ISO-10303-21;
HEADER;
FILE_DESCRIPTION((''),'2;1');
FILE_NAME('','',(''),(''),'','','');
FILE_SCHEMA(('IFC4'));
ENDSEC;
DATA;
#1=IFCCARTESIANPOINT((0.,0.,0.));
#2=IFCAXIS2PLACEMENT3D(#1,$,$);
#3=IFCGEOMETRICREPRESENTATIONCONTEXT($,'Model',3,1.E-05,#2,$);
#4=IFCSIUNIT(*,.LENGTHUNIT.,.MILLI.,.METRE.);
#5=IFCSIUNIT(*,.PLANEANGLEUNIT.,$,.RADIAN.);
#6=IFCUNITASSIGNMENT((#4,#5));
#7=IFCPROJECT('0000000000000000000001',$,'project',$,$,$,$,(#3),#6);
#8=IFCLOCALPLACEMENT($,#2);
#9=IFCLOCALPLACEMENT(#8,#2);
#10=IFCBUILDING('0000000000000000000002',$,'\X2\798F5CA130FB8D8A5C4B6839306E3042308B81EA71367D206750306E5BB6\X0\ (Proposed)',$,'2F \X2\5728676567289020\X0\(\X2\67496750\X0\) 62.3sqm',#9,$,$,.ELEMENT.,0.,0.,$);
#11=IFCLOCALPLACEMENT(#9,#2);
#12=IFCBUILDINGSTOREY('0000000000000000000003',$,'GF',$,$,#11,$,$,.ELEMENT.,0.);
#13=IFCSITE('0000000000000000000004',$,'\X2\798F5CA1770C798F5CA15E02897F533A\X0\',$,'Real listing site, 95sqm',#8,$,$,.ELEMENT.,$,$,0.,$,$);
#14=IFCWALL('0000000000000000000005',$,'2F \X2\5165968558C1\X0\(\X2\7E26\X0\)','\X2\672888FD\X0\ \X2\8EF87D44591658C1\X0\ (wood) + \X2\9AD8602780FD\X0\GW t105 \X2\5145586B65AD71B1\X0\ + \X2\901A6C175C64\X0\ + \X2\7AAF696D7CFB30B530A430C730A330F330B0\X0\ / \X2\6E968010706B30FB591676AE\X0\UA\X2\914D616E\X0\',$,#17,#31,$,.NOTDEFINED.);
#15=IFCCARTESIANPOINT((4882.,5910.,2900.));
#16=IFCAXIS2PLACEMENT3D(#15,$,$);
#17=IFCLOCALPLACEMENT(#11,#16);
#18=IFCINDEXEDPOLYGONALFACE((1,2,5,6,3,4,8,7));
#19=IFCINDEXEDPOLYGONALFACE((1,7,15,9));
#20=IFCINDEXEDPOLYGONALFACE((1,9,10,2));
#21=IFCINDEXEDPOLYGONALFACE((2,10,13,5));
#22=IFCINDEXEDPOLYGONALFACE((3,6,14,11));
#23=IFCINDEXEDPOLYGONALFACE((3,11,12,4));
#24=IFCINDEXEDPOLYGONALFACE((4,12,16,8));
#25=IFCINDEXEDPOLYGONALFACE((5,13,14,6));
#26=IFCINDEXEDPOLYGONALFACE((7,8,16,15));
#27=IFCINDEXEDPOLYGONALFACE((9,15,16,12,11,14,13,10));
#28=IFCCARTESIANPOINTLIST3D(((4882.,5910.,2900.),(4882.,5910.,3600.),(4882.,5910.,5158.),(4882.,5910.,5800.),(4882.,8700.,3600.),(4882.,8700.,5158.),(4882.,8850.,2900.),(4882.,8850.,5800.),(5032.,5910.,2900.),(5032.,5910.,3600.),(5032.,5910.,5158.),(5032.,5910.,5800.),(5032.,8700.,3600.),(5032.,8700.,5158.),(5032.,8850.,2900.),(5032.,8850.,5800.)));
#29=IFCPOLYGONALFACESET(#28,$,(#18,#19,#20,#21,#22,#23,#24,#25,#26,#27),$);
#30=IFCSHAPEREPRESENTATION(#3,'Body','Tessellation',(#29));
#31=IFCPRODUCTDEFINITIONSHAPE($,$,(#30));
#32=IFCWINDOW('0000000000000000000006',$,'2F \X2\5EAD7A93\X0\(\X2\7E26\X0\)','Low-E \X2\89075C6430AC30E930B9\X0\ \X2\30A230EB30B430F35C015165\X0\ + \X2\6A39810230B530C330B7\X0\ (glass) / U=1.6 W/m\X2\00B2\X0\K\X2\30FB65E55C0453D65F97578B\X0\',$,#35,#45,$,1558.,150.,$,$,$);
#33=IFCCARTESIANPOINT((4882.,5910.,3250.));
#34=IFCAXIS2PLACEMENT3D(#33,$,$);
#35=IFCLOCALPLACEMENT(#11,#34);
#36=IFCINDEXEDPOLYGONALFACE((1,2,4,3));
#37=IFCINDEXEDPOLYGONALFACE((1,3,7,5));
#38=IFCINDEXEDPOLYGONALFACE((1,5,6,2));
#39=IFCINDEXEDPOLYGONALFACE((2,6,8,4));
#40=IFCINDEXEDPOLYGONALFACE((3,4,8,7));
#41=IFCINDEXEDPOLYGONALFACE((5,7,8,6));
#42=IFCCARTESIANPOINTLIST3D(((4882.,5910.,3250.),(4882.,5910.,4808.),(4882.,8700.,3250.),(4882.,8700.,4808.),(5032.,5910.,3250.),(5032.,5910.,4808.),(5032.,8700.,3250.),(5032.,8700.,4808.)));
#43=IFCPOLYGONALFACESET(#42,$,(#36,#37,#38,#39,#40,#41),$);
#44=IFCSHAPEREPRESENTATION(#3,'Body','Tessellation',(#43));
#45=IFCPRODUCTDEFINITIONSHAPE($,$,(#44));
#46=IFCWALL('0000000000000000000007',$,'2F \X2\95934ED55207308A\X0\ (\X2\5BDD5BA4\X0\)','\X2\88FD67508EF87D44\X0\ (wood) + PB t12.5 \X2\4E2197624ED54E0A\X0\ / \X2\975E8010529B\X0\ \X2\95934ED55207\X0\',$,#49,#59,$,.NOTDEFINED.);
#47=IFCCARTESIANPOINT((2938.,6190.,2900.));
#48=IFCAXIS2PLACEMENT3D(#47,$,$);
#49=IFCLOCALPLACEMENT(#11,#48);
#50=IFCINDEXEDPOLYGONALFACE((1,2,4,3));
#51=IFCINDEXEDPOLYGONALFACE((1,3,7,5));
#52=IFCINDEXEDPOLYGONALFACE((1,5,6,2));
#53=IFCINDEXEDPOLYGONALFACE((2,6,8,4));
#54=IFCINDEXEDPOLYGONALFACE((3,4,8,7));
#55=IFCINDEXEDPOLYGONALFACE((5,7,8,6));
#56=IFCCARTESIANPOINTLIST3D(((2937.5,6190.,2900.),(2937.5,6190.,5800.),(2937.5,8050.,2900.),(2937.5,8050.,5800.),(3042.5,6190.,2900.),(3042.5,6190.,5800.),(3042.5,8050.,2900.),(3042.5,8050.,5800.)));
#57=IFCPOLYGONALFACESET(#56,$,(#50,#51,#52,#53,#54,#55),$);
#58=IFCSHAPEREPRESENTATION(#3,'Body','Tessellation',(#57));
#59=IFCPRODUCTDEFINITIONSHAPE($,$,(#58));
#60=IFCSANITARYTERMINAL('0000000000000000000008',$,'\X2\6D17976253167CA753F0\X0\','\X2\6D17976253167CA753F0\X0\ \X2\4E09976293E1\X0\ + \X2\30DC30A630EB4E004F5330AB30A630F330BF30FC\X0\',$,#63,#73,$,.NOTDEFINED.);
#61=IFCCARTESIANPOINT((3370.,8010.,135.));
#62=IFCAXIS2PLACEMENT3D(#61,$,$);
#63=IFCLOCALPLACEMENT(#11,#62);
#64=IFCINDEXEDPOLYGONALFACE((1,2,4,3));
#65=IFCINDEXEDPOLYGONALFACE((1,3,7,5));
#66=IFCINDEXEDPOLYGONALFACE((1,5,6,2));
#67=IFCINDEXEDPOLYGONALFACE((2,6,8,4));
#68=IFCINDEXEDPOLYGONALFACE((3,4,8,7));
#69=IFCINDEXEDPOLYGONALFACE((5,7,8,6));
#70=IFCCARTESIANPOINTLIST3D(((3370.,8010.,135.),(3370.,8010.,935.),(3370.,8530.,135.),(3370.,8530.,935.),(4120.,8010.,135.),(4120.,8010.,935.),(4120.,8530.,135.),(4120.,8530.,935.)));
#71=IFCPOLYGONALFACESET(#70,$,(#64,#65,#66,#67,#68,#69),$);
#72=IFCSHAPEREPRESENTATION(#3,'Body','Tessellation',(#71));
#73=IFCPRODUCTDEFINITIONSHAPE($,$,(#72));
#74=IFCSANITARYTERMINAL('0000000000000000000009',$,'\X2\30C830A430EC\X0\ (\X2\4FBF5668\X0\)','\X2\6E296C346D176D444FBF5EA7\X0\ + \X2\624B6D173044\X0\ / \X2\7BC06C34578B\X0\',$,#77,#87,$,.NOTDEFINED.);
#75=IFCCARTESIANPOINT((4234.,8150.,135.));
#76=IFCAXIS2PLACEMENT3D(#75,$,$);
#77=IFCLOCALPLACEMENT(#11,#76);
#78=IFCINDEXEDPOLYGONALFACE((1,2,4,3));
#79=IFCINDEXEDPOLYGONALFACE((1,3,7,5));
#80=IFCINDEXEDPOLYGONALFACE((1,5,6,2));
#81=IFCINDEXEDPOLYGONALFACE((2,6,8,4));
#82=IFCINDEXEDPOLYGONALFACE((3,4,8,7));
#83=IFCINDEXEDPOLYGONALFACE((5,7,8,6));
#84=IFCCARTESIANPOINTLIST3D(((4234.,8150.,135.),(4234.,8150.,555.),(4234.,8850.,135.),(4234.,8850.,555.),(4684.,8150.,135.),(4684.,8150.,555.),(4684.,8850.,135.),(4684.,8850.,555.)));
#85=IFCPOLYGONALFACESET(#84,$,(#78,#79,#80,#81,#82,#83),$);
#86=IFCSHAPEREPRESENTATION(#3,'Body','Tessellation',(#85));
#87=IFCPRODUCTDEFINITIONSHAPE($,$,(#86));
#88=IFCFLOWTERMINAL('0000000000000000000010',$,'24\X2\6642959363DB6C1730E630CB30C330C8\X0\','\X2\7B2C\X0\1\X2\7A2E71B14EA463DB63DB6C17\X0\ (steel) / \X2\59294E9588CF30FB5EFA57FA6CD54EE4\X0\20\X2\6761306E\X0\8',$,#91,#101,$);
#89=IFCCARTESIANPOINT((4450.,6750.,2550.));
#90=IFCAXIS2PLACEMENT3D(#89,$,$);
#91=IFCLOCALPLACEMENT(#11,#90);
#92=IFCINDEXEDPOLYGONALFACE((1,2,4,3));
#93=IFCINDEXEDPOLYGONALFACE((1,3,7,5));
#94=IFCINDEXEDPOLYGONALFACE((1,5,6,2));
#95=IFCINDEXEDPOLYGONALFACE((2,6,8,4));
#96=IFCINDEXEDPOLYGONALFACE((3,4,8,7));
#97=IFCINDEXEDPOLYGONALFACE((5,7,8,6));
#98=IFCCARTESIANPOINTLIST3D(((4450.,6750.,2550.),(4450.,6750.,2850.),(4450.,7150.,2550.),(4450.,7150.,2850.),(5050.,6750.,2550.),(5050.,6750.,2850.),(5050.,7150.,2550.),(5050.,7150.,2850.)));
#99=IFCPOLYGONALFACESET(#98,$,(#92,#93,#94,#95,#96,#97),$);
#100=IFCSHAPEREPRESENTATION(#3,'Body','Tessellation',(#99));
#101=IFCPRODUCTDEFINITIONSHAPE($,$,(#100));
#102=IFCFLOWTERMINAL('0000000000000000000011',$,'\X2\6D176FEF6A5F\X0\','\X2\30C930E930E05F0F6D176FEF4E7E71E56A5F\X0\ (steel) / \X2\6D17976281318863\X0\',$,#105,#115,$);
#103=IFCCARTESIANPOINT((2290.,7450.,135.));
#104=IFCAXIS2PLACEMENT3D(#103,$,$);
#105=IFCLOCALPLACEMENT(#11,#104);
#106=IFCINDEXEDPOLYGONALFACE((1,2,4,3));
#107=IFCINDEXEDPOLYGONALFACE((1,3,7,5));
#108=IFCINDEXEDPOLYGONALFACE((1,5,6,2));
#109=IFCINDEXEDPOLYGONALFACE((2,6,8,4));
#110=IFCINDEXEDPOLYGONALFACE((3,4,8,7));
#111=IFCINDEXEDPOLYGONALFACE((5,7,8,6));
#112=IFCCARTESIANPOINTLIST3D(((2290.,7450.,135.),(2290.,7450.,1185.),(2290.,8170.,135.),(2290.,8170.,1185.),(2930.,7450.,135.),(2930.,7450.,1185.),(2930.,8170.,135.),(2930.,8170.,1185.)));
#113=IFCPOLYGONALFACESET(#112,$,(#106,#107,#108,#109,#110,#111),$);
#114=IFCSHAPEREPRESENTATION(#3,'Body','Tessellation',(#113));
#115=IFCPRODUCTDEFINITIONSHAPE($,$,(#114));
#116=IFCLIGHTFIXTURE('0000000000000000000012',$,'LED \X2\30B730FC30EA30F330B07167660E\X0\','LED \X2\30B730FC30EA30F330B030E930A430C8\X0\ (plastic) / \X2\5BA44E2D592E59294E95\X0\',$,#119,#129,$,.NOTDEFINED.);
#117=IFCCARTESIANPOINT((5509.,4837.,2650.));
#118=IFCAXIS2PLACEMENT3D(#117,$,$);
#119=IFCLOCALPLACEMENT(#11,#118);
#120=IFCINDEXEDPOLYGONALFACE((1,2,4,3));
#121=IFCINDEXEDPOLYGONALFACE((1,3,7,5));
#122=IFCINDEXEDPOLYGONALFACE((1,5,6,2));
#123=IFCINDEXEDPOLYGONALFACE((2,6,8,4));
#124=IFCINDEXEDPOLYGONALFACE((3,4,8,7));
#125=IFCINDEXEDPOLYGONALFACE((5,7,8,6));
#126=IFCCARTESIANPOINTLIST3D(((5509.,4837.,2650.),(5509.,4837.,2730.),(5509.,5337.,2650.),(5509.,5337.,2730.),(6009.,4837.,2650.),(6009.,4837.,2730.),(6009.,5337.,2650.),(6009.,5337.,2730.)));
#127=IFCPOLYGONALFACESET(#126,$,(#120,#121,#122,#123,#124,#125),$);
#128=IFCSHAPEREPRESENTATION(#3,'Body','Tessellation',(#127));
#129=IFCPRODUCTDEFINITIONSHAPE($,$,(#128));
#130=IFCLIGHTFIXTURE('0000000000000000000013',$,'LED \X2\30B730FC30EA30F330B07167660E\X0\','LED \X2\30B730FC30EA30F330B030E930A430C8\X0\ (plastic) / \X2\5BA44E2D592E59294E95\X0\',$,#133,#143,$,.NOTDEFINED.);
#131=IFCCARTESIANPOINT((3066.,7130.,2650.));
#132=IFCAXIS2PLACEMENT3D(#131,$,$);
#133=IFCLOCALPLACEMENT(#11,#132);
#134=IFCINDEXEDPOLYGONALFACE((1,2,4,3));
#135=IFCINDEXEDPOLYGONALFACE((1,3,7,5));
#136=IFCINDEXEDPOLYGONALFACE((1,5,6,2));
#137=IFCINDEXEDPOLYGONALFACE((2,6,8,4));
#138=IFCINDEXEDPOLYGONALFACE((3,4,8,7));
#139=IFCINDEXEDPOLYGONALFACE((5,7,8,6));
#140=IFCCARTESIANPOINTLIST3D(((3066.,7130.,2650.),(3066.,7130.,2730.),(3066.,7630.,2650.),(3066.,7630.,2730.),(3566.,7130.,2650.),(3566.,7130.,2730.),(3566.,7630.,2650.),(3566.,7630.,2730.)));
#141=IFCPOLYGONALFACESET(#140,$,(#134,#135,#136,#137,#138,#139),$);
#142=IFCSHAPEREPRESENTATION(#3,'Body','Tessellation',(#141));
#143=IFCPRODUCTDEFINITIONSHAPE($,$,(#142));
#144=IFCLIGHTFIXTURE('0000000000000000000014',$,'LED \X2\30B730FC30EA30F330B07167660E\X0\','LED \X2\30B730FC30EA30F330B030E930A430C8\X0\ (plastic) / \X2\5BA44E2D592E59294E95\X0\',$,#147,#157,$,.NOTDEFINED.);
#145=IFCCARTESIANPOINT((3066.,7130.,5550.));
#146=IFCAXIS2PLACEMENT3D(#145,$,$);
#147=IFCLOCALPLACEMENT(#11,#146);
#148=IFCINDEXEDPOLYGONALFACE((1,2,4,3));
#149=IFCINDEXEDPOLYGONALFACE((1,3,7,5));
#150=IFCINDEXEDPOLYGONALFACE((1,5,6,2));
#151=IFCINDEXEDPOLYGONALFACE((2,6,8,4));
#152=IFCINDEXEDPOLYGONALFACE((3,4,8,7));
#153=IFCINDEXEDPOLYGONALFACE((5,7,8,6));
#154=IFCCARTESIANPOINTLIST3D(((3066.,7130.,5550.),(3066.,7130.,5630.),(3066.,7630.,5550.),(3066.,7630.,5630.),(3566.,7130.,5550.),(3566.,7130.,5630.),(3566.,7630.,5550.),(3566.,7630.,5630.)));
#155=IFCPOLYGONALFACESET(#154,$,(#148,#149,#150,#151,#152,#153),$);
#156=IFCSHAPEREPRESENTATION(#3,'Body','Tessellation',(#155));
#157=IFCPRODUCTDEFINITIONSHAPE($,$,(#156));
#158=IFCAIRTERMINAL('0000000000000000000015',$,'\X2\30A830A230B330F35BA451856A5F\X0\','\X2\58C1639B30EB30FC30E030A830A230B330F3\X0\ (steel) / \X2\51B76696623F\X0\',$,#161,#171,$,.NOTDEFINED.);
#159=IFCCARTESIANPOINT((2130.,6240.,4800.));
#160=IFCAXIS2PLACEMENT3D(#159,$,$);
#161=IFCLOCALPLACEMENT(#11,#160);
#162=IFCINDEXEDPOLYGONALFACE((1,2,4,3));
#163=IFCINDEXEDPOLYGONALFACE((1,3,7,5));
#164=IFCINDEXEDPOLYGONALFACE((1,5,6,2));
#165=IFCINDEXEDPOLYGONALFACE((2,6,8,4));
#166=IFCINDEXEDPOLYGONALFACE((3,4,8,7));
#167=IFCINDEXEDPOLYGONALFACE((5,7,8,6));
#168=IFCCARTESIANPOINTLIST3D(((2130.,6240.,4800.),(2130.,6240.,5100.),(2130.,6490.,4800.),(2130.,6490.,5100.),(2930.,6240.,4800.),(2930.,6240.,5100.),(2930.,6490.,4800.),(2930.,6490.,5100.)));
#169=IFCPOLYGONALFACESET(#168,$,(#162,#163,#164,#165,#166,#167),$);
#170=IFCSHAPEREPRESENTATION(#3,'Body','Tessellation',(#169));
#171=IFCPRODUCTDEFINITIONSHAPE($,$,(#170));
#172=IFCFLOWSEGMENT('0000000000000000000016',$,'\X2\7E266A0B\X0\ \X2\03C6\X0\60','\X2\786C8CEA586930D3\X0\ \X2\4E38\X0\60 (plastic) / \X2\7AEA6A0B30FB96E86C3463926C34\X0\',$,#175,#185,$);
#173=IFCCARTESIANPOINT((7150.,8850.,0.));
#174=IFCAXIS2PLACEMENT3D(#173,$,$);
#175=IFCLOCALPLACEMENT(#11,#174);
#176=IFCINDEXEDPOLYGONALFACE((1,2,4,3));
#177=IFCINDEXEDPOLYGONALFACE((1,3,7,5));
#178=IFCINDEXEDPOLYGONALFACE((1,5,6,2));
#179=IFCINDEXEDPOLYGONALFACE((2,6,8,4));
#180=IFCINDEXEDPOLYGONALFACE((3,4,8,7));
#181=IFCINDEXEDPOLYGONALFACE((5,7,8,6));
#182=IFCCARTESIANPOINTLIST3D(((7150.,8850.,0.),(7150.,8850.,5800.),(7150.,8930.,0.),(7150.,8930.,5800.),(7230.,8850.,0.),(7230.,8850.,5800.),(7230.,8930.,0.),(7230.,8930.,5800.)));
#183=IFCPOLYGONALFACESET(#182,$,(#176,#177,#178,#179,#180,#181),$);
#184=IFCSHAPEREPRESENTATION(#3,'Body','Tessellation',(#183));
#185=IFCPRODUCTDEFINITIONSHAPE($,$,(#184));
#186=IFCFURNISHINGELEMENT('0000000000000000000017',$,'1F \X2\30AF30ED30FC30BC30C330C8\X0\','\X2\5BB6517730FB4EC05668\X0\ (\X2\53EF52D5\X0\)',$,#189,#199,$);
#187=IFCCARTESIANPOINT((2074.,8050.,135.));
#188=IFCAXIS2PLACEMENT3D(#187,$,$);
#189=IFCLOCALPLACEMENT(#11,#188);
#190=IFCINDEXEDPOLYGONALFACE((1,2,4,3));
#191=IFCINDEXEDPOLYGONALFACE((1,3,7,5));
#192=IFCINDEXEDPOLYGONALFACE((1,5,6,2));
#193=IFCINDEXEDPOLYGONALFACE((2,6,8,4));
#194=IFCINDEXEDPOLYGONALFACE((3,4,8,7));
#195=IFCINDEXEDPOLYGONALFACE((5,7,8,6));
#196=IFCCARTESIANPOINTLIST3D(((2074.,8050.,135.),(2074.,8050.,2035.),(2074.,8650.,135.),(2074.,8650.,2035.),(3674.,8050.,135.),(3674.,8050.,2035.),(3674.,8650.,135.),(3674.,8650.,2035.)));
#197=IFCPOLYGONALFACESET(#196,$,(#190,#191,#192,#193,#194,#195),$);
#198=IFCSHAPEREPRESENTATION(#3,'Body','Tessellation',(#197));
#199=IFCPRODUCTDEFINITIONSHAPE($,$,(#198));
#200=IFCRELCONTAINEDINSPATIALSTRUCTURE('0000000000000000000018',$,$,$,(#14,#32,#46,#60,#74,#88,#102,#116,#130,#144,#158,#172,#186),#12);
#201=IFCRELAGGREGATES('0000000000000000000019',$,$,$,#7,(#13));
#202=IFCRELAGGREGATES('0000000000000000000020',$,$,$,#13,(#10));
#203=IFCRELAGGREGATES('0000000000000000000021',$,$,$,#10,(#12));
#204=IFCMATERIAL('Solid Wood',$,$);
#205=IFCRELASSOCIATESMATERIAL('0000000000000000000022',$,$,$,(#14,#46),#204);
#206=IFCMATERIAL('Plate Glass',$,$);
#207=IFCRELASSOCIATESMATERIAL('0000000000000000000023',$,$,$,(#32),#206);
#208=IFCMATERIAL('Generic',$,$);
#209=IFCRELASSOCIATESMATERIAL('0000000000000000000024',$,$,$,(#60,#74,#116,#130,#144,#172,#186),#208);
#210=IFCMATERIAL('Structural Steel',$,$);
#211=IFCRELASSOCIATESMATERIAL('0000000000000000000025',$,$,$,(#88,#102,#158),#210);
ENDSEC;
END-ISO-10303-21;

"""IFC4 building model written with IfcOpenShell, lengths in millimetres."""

from ifc_helpers import new_model, si_unit, frame, frame_2d, origin, place, context, project, spatial, rectangle, extrude, material, element, fill, save


model = new_model("IFC4")

# Units and contexts
model_context = context("Model", 3, precision=1e-05, world=origin())
ifc_project = project(units=[si_unit("LENGTHUNIT", "METRE", prefix="MILLI"), si_unit("PLANEANGLEUNIT", "RADIAN")], contexts=[model_context])

# Site, building, storey
site_placement = place(None, origin())
site = spatial("IfcSite", under=ifc_project, at=site_placement, Name="福岡県福岡市西区", ObjectType="Real listing site, 95sqm", CompositionType="ELEMENT", RefElevation=0.0)
building_placement = place(site_placement, origin())
building = spatial("IfcBuilding", under=site, at=building_placement, Name="福岡・越屋根のある自然素材の家 (Proposed)", ObjectType="2F 在来木造(杉材) 62.3sqm", CompositionType="ELEMENT", ElevationOfRefHeight=0.0, ElevationOfTerrain=0.0)
storey_placement = place(building_placement, origin())
storey = spatial("IfcBuildingStorey", under=building, at=storey_placement, Name="GF", CompositionType="ELEMENT", Elevation=0.0)

# Shared definitions
ifc_material_1 = material(Name="Solid Wood")

# Shared definitions
ifc_material_2 = material(Name="Plate Glass")

# Wall, opening, window
wall_1_placement = place(storey_placement, frame((4882.0, 5910.0, 2900.0)))
wall_1 = element("IfcWall", 1, at=wall_1_placement, inside=storey, material=ifc_material_1, Name="2F 入隅壁(縦)", Description="木製 軸組外壁 (wood) + 高性能GW t105 充填断熱 + 通気層 + 窯業系サイディング / 準耐火・外皮UA配慮", PredefinedType="NOTDEFINED", context=model_context, shape_type="SweptSolid", body=[
    extrude(rectangle(XDim=150.0, YDim=2940.0, at=frame_2d((75.0, 1470.0))), frame((4882.0, 5910.0, 2900.0)), (0.0, 0.0, 1.0), 2900.0),
])
opening_1_placement = place(storey_placement, frame((4882.0, 5910.0, 3250.0)))
opening_1 = element("IfcOpeningElement", 2, at=opening_1_placement, cuts=wall_1, PredefinedType="NOTDEFINED", context=model_context, shape_type="SweptSolid", body=[
    extrude(rectangle(XDim=150.0, YDim=2790.0, at=frame_2d((75.0, 1395.0))), frame((4882.0, 5910.0, 3250.0)), (0.0, 0.0, 1.0), 1558.0),
])
window_1_placement = place(storey_placement, frame((4882.0, 5910.0, 3250.0)))
window_1 = element("IfcWindow", 3, at=window_1_placement, inside=storey, material=ifc_material_2, Name="2F 庭窓(縦)", Description="Low-E 複層ガラス アルゴン封入 + 樹脂サッシ (glass) / U=1.6 W/m²K・日射取得型", OverallHeight=1558.0, OverallWidth=150.0, context=model_context, shape_type="SweptSolid", body=[
    extrude(rectangle(XDim=150.0, YDim=2790.0, at=frame_2d((75.0, 1395.0))), frame((4882.0, 5910.0, 3250.0)), (0.0, 0.0, 1.0), 1558.0),
])
fill(opening_1, window_1)

# Wall
wall_2_placement = place(storey_placement, frame((2938.0, 6190.0, 2900.0)))
element("IfcWall", 4, at=wall_2_placement, inside=storey, material=ifc_material_1, Name="2F 間仕切り (寝室)", Description="製材軸組 (wood) + PB t12.5 両面仕上 / 非耐力 間仕切", PredefinedType="NOTDEFINED", context=model_context, shape_type="SweptSolid", body=[
    extrude(rectangle(XDim=105.0, YDim=1860.0, at=frame_2d((52.0, 930.0))), frame((2938.0, 6190.0, 2900.0)), (0.0, 0.0, 1.0), 2900.0),
])

# Sanitary terminals
ifc_material_3 = material(Name="Generic")
sanitary_terminal_1_placement = place(storey_placement, frame((3370.0, 8010.0, 135.0)))
element("IfcSanitaryTerminal", 5, at=sanitary_terminal_1_placement, inside=storey, material=ifc_material_3, Name="洗面化粧台", Description="洗面化粧台 三面鏡 + ボウル一体カウンター", PredefinedType="NOTDEFINED", context=model_context, shape_type="SweptSolid", body=[
    extrude(rectangle(XDim=750.0, YDim=520.0, at=frame_2d((375.0, 260.0))), frame((3370.0, 8010.0, 135.0)), (0.0, 0.0, 1.0), 800.0),
])
sanitary_terminal_2_placement = place(storey_placement, frame((4234.0, 8150.0, 135.0)))
element("IfcSanitaryTerminal", 6, at=sanitary_terminal_2_placement, inside=storey, material=ifc_material_3, Name="トイレ (便器)", Description="温水洗浄便座 + 手洗い / 節水型", PredefinedType="NOTDEFINED", context=model_context, shape_type="SweptSolid", body=[
    extrude(rectangle(XDim=450.0, YDim=700.0, at=frame_2d((225.0, 350.0))), frame((4234.0, 8150.0, 135.0)), (0.0, 0.0, 1.0), 420.0),
])

# Flow terminals
ifc_material_4 = material(Name="Structural Steel")
flow_terminal_1_placement = place(storey_placement, frame((4450.0, 6750.0, 2550.0)))
element("IfcFlowTerminal", 7, at=flow_terminal_1_placement, inside=storey, material=ifc_material_4, Name="24時間換気ユニット", Description="第1種熱交換換気 (steel) / 天井裏・建基法令20条の8", context=model_context, shape_type="SweptSolid", body=[
    extrude(rectangle(XDim=600.0, YDim=400.0, at=frame_2d((300.0, 200.0))), frame((4450.0, 6750.0, 2550.0)), (0.0, 0.0, 1.0), 300.0),
])
flow_terminal_2_placement = place(storey_placement, frame((2290.0, 7450.0, 135.0)))
element("IfcFlowTerminal", 8, at=flow_terminal_2_placement, inside=storey, material=ifc_material_4, Name="洗濯機", Description="ドラム式洗濯乾燥機 (steel) / 洗面脱衣", context=model_context, shape_type="SweptSolid", body=[
    extrude(rectangle(XDim=640.0, YDim=720.0, at=frame_2d((320.0, 360.0))), frame((2290.0, 7450.0, 135.0)), (0.0, 0.0, 1.0), 1050.0),
])

# Light fixtures
light_fixture_1_placement = place(storey_placement, frame((5509.0, 4837.0, 2650.0)))
element("IfcLightFixture", 9, at=light_fixture_1_placement, inside=storey, material=ifc_material_3, Name="LED シーリング照明", Description="LED シーリングライト (plastic) / 室中央天井", PredefinedType="NOTDEFINED", context=model_context, shape_type="SweptSolid", body=[
    extrude(rectangle(XDim=500.0, YDim=500.0, at=frame_2d((250.0, 250.0))), frame((5509.0, 4837.0, 2650.0)), (0.0, 0.0, 1.0), 80.0),
])
light_fixture_2_placement = place(storey_placement, frame((3066.0, 7130.0, 2650.0)))
element("IfcLightFixture", 10, at=light_fixture_2_placement, inside=storey, material=ifc_material_3, Name="LED シーリング照明", Description="LED シーリングライト (plastic) / 室中央天井", PredefinedType="NOTDEFINED", context=model_context, shape_type="SweptSolid", body=[
    extrude(rectangle(XDim=500.0, YDim=500.0, at=frame_2d((250.0, 250.0))), frame((3066.0, 7130.0, 2650.0)), (0.0, 0.0, 1.0), 80.0),
])
light_fixture_3_placement = place(storey_placement, frame((3066.0, 7130.0, 5550.0)))
element("IfcLightFixture", 11, at=light_fixture_3_placement, inside=storey, material=ifc_material_3, Name="LED シーリング照明", Description="LED シーリングライト (plastic) / 室中央天井", PredefinedType="NOTDEFINED", context=model_context, shape_type="SweptSolid", body=[
    extrude(rectangle(XDim=500.0, YDim=500.0, at=frame_2d((250.0, 250.0))), frame((3066.0, 7130.0, 5550.0)), (0.0, 0.0, 1.0), 80.0),
])

# Air terminal
air_terminal_placement = place(storey_placement, frame((2130.0, 6240.0, 4800.0)))
element("IfcAirTerminal", 12, at=air_terminal_placement, inside=storey, material=ifc_material_4, Name="エアコン室内機", Description="壁掛ルームエアコン (steel) / 冷暖房", PredefinedType="NOTDEFINED", context=model_context, shape_type="SweptSolid", body=[
    extrude(rectangle(XDim=800.0, YDim=250.0, at=frame_2d((400.0, 125.0))), frame((2130.0, 6240.0, 4800.0)), (0.0, 0.0, 1.0), 300.0),
])

# Flow segment
flow_segment_placement = place(storey_placement, frame((7150.0, 8850.0, 0.0)))
element("IfcFlowSegment", 13, at=flow_segment_placement, inside=storey, material=ifc_material_3, Name="縦樋 φ60", Description="硬質塩ビ 丸60 (plastic) / 竪樋・雨水排水", context=model_context, shape_type="SweptSolid", body=[
    extrude(rectangle(XDim=80.0, YDim=80.0, at=frame_2d((40.0, 40.0))), frame((7150.0, 8850.0, 0.0)), (0.0, 0.0, 1.0), 5800.0),
])

# Furnishing element
furnishing_1_placement = place(storey_placement, frame((2074.0, 8050.0, 135.0)))
element("IfcFurnishingElement", 14, at=furnishing_1_placement, inside=storey, material=ifc_material_3, Name="1F クローゼット", Description="家具・什器 (可動)", context=model_context, shape_type="SweptSolid", body=[
    extrude(rectangle(XDim=1600.0, YDim=600.0, at=frame_2d((800.0, 300.0))), frame((2074.0, 8050.0, 135.0)), (0.0, 0.0, 1.0), 1900.0),
])

save(model, "model.ifc")
